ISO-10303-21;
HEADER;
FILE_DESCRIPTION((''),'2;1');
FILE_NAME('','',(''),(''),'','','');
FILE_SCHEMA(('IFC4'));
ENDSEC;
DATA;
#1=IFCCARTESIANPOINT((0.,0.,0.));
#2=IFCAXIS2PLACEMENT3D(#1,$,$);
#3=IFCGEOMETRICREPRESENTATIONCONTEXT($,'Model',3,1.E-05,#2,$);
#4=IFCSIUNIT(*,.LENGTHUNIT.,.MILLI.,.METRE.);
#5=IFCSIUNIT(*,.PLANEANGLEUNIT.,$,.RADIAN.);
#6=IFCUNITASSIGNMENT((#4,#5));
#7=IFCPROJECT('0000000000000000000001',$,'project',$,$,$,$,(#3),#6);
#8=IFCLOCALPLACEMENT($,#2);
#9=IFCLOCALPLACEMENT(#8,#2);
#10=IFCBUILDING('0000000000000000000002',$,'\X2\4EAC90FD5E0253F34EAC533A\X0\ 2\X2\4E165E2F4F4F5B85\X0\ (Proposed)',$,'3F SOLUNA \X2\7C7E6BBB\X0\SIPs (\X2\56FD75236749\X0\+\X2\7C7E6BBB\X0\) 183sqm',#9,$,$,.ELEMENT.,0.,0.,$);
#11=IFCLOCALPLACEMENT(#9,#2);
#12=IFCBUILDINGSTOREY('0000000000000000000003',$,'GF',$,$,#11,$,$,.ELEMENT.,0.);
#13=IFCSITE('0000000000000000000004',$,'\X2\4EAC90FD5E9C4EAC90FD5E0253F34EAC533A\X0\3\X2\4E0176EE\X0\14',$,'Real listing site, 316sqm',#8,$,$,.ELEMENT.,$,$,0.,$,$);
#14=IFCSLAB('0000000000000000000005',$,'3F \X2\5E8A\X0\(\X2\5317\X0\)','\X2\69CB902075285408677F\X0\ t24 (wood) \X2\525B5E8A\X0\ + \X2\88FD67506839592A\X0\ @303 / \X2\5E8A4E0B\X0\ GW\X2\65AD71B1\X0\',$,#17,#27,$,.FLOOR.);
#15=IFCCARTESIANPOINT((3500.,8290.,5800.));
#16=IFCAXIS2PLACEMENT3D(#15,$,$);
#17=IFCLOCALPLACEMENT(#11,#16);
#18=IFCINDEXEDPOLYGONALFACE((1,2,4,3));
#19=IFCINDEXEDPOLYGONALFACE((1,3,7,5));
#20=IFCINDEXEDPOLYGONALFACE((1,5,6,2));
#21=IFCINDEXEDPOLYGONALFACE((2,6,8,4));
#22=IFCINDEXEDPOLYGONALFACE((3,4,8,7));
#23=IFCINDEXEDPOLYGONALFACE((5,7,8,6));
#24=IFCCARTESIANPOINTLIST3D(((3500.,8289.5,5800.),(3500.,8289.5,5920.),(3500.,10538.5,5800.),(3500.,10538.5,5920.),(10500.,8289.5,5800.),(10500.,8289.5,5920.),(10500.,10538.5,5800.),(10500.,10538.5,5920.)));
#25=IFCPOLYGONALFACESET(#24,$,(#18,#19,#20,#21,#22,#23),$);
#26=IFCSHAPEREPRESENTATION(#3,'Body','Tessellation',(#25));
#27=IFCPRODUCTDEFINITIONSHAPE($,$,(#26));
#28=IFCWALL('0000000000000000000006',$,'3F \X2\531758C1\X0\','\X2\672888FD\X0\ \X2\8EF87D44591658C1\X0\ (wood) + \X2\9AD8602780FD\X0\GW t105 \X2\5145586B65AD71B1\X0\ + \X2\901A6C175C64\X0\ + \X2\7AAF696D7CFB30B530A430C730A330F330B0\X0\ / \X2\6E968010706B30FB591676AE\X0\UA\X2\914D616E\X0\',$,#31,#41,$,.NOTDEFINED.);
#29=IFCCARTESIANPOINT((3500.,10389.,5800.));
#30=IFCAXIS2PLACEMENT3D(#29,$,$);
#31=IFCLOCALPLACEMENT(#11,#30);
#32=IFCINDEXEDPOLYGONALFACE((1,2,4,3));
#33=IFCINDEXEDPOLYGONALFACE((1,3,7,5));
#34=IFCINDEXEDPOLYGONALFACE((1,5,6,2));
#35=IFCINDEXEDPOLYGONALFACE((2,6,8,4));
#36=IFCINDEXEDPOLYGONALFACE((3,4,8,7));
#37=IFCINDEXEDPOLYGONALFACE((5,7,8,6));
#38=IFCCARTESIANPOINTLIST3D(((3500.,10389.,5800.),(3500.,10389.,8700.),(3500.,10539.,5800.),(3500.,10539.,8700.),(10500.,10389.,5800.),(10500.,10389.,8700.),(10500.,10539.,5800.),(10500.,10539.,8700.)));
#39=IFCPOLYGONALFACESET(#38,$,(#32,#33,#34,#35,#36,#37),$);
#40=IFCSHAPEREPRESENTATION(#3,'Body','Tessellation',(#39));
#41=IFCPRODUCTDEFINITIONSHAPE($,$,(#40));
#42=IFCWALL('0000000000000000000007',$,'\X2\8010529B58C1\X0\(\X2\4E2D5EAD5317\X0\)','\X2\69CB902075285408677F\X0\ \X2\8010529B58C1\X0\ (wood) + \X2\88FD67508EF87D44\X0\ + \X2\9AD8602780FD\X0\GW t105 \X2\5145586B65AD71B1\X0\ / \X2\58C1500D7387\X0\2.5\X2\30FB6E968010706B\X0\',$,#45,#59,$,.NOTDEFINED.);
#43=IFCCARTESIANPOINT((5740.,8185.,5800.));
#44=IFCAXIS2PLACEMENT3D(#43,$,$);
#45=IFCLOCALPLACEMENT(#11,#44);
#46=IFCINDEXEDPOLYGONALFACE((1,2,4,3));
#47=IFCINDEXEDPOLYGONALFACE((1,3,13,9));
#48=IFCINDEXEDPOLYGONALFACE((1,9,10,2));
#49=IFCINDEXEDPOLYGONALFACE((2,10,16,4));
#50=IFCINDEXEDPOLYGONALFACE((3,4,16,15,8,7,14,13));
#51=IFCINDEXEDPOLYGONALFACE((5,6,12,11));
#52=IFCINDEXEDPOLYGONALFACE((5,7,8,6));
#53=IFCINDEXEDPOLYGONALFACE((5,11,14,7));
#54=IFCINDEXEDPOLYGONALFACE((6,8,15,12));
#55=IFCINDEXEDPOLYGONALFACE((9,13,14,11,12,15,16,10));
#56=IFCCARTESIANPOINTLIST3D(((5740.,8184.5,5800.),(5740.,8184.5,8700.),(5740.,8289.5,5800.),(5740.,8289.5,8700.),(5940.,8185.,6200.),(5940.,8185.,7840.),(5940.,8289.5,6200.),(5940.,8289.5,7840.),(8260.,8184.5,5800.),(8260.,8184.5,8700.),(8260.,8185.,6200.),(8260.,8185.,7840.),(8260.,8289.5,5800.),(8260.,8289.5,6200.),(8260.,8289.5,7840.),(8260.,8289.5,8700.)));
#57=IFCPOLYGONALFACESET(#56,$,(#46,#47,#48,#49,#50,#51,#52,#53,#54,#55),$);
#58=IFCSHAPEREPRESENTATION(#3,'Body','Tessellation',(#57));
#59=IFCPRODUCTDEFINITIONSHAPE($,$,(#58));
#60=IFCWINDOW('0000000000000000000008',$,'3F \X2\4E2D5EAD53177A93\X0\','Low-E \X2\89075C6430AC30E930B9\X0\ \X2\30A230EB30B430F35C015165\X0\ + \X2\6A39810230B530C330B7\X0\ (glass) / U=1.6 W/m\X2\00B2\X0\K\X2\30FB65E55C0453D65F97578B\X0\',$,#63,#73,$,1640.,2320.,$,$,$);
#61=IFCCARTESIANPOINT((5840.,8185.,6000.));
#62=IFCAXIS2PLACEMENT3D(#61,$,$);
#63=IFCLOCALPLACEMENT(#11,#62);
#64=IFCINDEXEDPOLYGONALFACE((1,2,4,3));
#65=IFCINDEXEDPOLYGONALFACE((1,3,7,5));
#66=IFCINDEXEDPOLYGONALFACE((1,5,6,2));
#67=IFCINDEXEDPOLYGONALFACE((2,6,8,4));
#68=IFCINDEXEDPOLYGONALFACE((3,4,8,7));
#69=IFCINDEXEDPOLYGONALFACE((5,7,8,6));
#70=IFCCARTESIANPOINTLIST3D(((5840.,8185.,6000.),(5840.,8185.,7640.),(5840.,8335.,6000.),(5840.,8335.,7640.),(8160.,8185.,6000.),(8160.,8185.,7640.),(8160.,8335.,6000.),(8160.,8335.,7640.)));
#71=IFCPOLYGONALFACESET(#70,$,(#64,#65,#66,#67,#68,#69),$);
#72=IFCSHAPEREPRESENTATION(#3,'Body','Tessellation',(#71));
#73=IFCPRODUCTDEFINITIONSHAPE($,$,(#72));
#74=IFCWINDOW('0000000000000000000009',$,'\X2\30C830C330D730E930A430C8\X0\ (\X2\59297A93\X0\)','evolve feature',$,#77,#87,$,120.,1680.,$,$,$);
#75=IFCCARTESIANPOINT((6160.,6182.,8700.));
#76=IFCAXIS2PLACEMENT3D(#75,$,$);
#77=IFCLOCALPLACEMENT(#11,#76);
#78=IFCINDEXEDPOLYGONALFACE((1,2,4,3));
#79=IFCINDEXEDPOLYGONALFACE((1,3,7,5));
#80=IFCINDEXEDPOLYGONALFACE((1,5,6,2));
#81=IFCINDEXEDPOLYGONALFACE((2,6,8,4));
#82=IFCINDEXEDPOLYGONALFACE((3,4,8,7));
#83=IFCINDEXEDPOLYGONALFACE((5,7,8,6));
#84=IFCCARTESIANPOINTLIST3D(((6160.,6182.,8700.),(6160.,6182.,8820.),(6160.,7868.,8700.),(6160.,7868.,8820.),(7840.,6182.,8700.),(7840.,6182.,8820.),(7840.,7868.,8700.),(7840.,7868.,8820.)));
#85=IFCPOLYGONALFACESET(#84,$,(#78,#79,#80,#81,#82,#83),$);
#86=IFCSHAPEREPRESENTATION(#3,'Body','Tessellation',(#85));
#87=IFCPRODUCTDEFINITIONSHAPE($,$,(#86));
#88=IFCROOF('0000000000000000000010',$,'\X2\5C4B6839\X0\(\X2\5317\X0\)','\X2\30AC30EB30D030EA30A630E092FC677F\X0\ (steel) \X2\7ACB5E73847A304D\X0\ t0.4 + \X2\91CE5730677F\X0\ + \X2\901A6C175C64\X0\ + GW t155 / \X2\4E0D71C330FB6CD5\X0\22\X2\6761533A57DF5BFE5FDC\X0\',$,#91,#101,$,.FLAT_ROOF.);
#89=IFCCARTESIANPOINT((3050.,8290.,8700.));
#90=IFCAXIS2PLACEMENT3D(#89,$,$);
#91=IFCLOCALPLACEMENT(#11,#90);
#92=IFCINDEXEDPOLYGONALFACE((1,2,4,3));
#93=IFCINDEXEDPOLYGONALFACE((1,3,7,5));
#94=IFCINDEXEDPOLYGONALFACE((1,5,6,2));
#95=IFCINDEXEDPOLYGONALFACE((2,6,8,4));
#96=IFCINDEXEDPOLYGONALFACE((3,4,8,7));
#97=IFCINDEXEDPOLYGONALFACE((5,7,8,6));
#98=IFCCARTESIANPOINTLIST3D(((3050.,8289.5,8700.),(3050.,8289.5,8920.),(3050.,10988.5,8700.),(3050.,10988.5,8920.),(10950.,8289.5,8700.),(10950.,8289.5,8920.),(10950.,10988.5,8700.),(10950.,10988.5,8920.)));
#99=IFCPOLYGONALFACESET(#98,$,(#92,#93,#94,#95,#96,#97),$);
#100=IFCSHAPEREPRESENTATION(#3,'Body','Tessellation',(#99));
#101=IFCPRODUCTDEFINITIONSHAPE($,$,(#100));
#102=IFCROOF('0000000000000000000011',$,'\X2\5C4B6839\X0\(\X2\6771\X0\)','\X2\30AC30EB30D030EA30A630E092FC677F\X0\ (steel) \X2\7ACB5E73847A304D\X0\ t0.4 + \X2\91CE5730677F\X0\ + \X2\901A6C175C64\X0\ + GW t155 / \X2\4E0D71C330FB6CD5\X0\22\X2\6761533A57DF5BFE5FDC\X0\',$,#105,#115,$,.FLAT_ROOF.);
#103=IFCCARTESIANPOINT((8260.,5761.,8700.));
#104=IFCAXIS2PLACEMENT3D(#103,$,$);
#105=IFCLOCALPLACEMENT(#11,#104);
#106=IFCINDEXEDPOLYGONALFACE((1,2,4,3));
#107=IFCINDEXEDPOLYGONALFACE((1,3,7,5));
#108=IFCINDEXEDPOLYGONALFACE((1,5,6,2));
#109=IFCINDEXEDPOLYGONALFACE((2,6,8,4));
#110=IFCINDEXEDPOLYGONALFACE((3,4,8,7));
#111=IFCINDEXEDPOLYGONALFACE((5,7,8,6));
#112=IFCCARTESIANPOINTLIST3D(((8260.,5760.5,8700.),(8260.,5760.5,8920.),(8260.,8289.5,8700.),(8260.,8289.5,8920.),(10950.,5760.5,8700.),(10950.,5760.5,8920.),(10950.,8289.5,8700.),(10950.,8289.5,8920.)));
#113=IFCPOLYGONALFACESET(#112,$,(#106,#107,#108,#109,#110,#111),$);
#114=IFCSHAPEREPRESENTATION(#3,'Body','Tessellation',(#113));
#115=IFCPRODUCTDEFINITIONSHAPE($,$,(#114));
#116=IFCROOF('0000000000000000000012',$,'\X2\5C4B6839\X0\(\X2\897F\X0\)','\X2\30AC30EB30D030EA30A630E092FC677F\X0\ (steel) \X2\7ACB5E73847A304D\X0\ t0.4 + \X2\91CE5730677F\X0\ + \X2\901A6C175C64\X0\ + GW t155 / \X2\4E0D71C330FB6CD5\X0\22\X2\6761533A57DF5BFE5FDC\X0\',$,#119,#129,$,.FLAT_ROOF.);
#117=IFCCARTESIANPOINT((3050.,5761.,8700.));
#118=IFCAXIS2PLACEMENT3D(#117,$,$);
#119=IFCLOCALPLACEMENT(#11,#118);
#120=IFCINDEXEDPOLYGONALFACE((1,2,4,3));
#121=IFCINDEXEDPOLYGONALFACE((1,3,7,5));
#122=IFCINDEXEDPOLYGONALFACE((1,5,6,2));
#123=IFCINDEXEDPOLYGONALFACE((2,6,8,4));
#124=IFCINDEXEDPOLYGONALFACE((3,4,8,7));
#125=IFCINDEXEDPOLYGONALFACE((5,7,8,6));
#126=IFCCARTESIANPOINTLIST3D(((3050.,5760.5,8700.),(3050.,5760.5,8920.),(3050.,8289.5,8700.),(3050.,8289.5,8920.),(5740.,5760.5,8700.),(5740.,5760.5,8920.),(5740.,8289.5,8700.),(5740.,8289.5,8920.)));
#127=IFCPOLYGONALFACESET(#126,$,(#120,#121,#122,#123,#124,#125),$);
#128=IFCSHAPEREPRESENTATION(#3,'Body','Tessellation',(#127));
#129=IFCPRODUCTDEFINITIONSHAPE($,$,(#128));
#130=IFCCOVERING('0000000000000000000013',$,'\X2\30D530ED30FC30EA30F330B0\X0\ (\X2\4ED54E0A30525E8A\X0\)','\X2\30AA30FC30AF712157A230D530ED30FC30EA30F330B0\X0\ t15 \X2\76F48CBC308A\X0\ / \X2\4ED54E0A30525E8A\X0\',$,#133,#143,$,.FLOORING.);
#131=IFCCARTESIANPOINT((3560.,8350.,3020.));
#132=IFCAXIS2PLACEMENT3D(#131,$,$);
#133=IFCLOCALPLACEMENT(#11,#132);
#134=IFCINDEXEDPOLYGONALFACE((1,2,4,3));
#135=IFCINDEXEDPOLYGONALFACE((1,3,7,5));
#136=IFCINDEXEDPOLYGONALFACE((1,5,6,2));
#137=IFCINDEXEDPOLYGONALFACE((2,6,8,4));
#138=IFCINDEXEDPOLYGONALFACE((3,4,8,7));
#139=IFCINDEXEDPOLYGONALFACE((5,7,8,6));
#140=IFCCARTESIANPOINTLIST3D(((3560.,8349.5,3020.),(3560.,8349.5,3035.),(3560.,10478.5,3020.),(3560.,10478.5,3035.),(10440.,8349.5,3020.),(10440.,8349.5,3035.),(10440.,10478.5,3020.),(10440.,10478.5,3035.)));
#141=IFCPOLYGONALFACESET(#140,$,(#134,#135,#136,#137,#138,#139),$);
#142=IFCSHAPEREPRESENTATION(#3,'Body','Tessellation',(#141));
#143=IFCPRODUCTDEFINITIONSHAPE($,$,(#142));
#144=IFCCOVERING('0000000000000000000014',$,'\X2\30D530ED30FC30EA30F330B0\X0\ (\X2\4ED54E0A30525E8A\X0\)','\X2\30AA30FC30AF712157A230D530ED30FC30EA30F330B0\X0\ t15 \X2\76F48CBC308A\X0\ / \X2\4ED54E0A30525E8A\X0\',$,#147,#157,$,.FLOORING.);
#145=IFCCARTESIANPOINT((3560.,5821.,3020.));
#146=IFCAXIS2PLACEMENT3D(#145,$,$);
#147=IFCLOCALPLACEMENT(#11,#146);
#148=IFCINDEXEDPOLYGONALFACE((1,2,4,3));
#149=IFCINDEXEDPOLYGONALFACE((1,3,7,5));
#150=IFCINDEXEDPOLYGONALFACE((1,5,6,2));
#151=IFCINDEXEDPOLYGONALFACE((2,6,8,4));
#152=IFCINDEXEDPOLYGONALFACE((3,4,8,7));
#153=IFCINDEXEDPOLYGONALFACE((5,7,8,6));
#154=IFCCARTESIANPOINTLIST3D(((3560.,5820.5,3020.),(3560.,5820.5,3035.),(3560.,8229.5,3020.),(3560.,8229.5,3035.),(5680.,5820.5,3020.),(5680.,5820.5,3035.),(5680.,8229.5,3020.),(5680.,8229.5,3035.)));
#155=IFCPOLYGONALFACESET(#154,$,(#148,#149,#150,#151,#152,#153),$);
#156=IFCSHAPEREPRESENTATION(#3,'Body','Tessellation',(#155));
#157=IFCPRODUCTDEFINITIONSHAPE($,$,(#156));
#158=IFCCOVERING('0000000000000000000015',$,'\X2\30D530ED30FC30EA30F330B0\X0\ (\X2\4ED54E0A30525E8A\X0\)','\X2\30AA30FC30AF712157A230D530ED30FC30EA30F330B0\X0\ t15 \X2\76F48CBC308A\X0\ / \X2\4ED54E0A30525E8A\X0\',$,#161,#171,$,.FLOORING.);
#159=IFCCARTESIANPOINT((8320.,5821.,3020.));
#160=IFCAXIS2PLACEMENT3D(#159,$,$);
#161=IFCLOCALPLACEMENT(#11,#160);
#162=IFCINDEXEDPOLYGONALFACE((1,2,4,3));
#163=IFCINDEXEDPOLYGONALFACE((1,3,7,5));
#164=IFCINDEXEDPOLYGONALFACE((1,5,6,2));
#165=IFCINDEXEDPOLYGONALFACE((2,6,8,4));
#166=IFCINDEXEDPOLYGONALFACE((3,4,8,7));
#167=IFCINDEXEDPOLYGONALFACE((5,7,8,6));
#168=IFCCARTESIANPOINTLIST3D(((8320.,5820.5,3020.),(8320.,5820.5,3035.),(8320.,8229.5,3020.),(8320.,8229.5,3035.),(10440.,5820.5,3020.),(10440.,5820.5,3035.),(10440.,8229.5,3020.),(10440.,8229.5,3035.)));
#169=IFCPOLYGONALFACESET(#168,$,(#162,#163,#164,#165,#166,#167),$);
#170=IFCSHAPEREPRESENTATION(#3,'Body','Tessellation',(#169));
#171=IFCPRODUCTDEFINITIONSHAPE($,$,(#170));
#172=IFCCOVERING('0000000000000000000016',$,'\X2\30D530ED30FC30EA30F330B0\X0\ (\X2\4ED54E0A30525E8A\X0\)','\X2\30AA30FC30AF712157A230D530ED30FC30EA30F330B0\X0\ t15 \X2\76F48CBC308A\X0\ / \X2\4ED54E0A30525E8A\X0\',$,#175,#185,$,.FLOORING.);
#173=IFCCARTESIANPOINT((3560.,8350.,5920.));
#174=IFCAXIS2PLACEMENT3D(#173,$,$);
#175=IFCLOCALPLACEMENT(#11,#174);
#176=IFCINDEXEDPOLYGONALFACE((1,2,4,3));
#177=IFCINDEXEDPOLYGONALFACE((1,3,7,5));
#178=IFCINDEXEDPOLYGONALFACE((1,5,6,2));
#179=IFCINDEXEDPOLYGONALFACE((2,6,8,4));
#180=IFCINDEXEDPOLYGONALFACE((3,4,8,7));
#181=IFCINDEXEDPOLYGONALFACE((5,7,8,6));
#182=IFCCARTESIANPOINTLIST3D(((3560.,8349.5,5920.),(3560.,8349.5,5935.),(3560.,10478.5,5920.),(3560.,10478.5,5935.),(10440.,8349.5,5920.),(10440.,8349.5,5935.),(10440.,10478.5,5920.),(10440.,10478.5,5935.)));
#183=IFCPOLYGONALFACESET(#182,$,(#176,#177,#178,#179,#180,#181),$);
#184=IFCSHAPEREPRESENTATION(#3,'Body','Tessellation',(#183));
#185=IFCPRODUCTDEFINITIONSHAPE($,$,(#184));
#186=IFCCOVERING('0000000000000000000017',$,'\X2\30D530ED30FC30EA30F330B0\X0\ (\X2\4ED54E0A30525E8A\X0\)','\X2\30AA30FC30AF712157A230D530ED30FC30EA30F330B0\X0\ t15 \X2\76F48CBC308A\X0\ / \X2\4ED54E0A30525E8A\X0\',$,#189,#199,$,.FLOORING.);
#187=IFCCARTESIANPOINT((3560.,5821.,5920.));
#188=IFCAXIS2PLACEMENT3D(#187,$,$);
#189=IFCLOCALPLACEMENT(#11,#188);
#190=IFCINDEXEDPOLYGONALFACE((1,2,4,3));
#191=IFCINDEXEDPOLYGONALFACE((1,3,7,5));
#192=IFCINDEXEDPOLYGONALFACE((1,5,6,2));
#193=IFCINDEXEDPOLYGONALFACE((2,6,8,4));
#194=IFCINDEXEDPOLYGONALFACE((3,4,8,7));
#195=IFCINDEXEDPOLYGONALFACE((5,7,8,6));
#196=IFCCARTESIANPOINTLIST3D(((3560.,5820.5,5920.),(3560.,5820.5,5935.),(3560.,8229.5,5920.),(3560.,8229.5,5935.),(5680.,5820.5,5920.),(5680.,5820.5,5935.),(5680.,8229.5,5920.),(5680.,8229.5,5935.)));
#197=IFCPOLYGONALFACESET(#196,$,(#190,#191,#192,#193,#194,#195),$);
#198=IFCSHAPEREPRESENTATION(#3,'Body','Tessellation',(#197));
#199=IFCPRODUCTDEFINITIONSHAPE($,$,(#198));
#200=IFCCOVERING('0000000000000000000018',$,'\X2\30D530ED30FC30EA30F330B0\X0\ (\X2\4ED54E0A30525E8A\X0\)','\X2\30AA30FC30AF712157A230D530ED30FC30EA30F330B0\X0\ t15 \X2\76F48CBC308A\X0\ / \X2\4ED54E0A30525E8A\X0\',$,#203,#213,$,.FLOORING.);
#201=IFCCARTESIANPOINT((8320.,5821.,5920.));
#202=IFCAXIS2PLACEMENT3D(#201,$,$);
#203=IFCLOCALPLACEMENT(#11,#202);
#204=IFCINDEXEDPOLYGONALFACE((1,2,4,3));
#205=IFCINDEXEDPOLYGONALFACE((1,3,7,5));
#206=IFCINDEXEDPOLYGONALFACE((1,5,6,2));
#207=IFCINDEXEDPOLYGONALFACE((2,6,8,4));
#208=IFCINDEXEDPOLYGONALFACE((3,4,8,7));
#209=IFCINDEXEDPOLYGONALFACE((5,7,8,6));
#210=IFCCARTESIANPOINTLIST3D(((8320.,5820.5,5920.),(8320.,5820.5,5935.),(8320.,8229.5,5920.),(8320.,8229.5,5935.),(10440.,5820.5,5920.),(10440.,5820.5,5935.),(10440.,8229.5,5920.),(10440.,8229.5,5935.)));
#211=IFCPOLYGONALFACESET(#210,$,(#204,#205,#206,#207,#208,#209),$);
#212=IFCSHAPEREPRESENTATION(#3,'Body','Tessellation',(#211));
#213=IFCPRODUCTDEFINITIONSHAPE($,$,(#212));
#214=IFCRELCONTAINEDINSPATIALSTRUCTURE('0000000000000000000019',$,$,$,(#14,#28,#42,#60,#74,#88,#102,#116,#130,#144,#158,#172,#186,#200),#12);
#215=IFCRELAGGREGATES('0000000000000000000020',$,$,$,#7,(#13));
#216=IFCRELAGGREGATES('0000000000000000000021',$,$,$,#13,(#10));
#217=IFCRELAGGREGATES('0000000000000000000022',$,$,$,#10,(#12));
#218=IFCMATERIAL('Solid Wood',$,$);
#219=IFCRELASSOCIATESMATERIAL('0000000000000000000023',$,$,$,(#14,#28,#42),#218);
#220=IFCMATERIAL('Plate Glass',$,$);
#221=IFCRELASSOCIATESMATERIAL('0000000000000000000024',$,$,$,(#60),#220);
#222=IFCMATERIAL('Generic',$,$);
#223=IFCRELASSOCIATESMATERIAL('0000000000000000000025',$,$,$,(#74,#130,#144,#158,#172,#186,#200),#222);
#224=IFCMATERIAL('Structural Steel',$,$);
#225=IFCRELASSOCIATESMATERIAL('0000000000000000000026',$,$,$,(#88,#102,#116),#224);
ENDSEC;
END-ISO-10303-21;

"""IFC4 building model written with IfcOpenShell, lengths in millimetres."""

from ifc_helpers import new_model, si_unit, frame, frame_2d, origin, place, context, project, spatial, rectangle, extrude, material, element, fill, save


model = new_model("IFC4")

# Units and contexts
model_context = context("Model", 3, precision=1e-05, world=origin())
ifc_project = project(units=[si_unit("LENGTHUNIT", "METRE", prefix="MILLI"), si_unit("PLANEANGLEUNIT", "RADIAN")], contexts=[model_context])

# Site, building, storey
site_placement = place(None, origin())
site = spatial("IfcSite", under=ifc_project, at=site_placement, Name="京都府京都市右京区3丁目14", ObjectType="Real listing site, 316sqm", CompositionType="ELEMENT", RefElevation=0.0)
building_placement = place(site_placement, origin())
building = spatial("IfcBuilding", under=site, at=building_placement, Name="京都市右京区 2世帯住宅 (Proposed)", ObjectType="3F SOLUNA 籾殻SIPs (国産杉+籾殻) 183sqm", CompositionType="ELEMENT", ElevationOfRefHeight=0.0, ElevationOfTerrain=0.0)
storey_placement = place(building_placement, origin())
storey = spatial("IfcBuildingStorey", under=building, at=storey_placement, Name="GF", CompositionType="ELEMENT", Elevation=0.0)

# Slab
ifc_material_1 = material(Name="Solid Wood")
slab_placement = place(storey_placement, frame((3500.0, 8290.0, 5800.0)))
element("IfcSlab", 1, at=slab_placement, inside=storey, material=ifc_material_1, Name="3F 床(北)", Description="構造用合板 t24 (wood) 剛床 + 製材根太 @303 / 床下 GW断熱", PredefinedType="FLOOR", context=model_context, shape_type="SweptSolid", body=[
    extrude(rectangle(XDim=7000.0, YDim=2249.0, at=frame_2d((3500.0, 1124.0))), frame((3500.0, 8290.0, 5800.0)), (0.0, 0.0, 1.0), 120.0),
])

# Wall
wall_1_placement = place(storey_placement, frame((3500.0, 10389.0, 5800.0)))
element("IfcWall", 2, at=wall_1_placement, inside=storey, material=ifc_material_1, Name="3F 北壁", Description="木製 軸組外壁 (wood) + 高性能GW t105 充填断熱 + 通気層 + 窯業系サイディング / 準耐火・外皮UA配慮", PredefinedType="NOTDEFINED", context=model_context, shape_type="SweptSolid", body=[
    extrude(rectangle(XDim=7000.0, YDim=150.0, at=frame_2d((3500.0, 75.0))), frame((3500.0, 10389.0, 5800.0)), (0.0, 0.0, 1.0), 2900.0),
])

# Wall, opening, window
wall_2_placement = place(storey_placement, frame((5740.0, 8185.0, 5800.0)))
wall_2 = element("IfcWall", 3, at=wall_2_placement, inside=storey, material=ifc_material_1, Name="耐力壁(中庭北)", Description="構造用合板 耐力壁 (wood) + 製材軸組 + 高性能GW t105 充填断熱 / 壁倍率2.5・準耐火", PredefinedType="NOTDEFINED", context=model_context, shape_type="SweptSolid", body=[
    extrude(rectangle(XDim=2520.0, YDim=105.0, at=frame_2d((1260.0, 52.0))), frame((5740.0, 8185.0, 5800.0)), (0.0, 0.0, 1.0), 2900.0),
])
opening_placement = place(storey_placement, frame((5840.0, 8185.0, 6000.0)))
opening = element("IfcOpeningElement", 4, at=opening_placement, cuts=wall_2, PredefinedType="NOTDEFINED", context=model_context, shape_type="SweptSolid", body=[
    extrude(rectangle(XDim=2320.0, YDim=150.0, at=frame_2d((1160.0, 75.0))), frame((5840.0, 8185.0, 6000.0)), (0.0, 0.0, 1.0), 1640.0),
])
ifc_material_2 = material(Name="Plate Glass")
window_1_placement = place(storey_placement, frame((5840.0, 8185.0, 6000.0)))
window_1 = element("IfcWindow", 5, at=window_1_placement, inside=storey, material=ifc_material_2, Name="3F 中庭北窓", Description="Low-E 複層ガラス アルゴン封入 + 樹脂サッシ (glass) / U=1.6 W/m²K・日射取得型", OverallHeight=1640.0, OverallWidth=2320.0, context=model_context, shape_type="SweptSolid", body=[
    extrude(rectangle(XDim=2320.0, YDim=150.0, at=frame_2d((1160.0, 75.0))), frame((5840.0, 8185.0, 6000.0)), (0.0, 0.0, 1.0), 1640.0),
])
fill(opening, window_1)

# Window
ifc_material_3 = material(Name="Generic")
window_2_placement = place(storey_placement, frame((6160.0, 6182.0, 8700.0)))
element("IfcWindow", 6, at=window_2_placement, inside=storey, material=ifc_material_3, Name="トップライト (天窓)", Description="evolve feature", OverallHeight=120.0, OverallWidth=1680.0, context=model_context, shape_type="SweptSolid", body=[
    extrude(rectangle(XDim=1680.0, YDim=1686.0, at=frame_2d((840.0, 843.0))), frame((6160.0, 6182.0, 8700.0)), (0.0, 0.0, 1.0), 120.0),
])

# Roofs
ifc_material_4 = material(Name="Structural Steel")
roof_1_placement = place(storey_placement, frame((3050.0, 8290.0, 8700.0)))
element("IfcRoof", 7, at=roof_1_placement, inside=storey, material=ifc_material_4, Name="屋根(北)", Description="ガルバリウム鋼板 (steel) 立平葺き t0.4 + 野地板 + 通気層 + GW t155 / 不燃・法22条区域対応", PredefinedType="FLAT_ROOF", context=model_context, shape_type="SweptSolid", body=[
    extrude(rectangle(XDim=7900.0, YDim=2699.0, at=frame_2d((3950.0, 1349.0))), frame((3050.0, 8290.0, 8700.0)), (0.0, 0.0, 1.0), 220.0),
])
roof_2_placement = place(storey_placement, frame((8260.0, 5761.0, 8700.0)))
element("IfcRoof", 8, at=roof_2_placement, inside=storey, material=ifc_material_4, Name="屋根(東)", Description="ガルバリウム鋼板 (steel) 立平葺き t0.4 + 野地板 + 通気層 + GW t155 / 不燃・法22条区域対応", PredefinedType="FLAT_ROOF", context=model_context, shape_type="SweptSolid", body=[
    extrude(rectangle(XDim=2690.0, YDim=2529.0, at=frame_2d((1345.0, 1264.0))), frame((8260.0, 5761.0, 8700.0)), (0.0, 0.0, 1.0), 220.0),
])
roof_3_placement = place(storey_placement, frame((3050.0, 5761.0, 8700.0)))
element("IfcRoof", 9, at=roof_3_placement, inside=storey, material=ifc_material_4, Name="屋根(西)", Description="ガルバリウム鋼板 (steel) 立平葺き t0.4 + 野地板 + 通気層 + GW t155 / 不燃・法22条区域対応", PredefinedType="FLAT_ROOF", context=model_context, shape_type="SweptSolid", body=[
    extrude(rectangle(XDim=2690.0, YDim=2529.0, at=frame_2d((1345.0, 1264.0))), frame((3050.0, 5761.0, 8700.0)), (0.0, 0.0, 1.0), 220.0),
])

# Coverings
covering_1_placement = place(storey_placement, frame((3560.0, 8350.0, 3020.0)))
element("IfcCovering", 10, at=covering_1_placement, inside=storey, material=ifc_material_3, Name="フローリング (仕上げ床)", Description="オーク無垢フローリング t15 直貼り / 仕上げ床", PredefinedType="FLOORING", context=model_context, shape_type="SweptSolid", body=[
    extrude(rectangle(XDim=6880.0, YDim=2129.0, at=frame_2d((3440.0, 1064.0))), frame((3560.0, 8350.0, 3020.0)), (0.0, 0.0, 1.0), 15.0),
])
covering_2_placement = place(storey_placement, frame((3560.0, 5821.0, 3020.0)))
element("IfcCovering", 11, at=covering_2_placement, inside=storey, material=ifc_material_3, Name="フローリング (仕上げ床)", Description="オーク無垢フローリング t15 直貼り / 仕上げ床", PredefinedType="FLOORING", context=model_context, shape_type="SweptSolid", body=[
    extrude(rectangle(XDim=2120.0, YDim=2409.0, at=frame_2d((1060.0, 1204.0))), frame((3560.0, 5821.0, 3020.0)), (0.0, 0.0, 1.0), 15.0),
])
covering_3_placement = place(storey_placement, frame((8320.0, 5821.0, 3020.0)))
element("IfcCovering", 12, at=covering_3_placement, inside=storey, material=ifc_material_3, Name="フローリング (仕上げ床)", Description="オーク無垢フローリング t15 直貼り / 仕上げ床", PredefinedType="FLOORING", context=model_context, shape_type="SweptSolid", body=[
    extrude(rectangle(XDim=2120.0, YDim=2409.0, at=frame_2d((1060.0, 1204.0))), frame((8320.0, 5821.0, 3020.0)), (0.0, 0.0, 1.0), 15.0),
])
covering_4_placement = place(storey_placement, frame((3560.0, 8350.0, 5920.0)))
element("IfcCovering", 13, at=covering_4_placement, inside=storey, material=ifc_material_3, Name="フローリング (仕上げ床)", Description="オーク無垢フローリング t15 直貼り / 仕上げ床", PredefinedType="FLOORING", context=model_context, shape_type="SweptSolid", body=[
    extrude(rectangle(XDim=6880.0, YDim=2129.0, at=frame_2d((3440.0, 1064.0))), frame((3560.0, 8350.0, 5920.0)), (0.0, 0.0, 1.0), 15.0),
])
covering_5_placement = place(storey_placement, frame((3560.0, 5821.0, 5920.0)))
element("IfcCovering", 14, at=covering_5_placement, inside=storey, material=ifc_material_3, Name="フローリング (仕上げ床)", Description="オーク無垢フローリング t15 直貼り / 仕上げ床", PredefinedType="FLOORING", context=model_context, shape_type="SweptSolid", body=[
    extrude(rectangle(XDim=2120.0, YDim=2409.0, at=frame_2d((1060.0, 1204.0))), frame((3560.0, 5821.0, 5920.0)), (0.0, 0.0, 1.0), 15.0),
])
covering_6_placement = place(storey_placement, frame((8320.0, 5821.0, 5920.0)))
element("IfcCovering", 15, at=covering_6_placement, inside=storey, material=ifc_material_3, Name="フローリング (仕上げ床)", Description="オーク無垢フローリング t15 直貼り / 仕上げ床", PredefinedType="FLOORING", context=model_context, shape_type="SweptSolid", body=[
    extrude(rectangle(XDim=2120.0, YDim=2409.0, at=frame_2d((1060.0, 1204.0))), frame((8320.0, 5821.0, 5920.0)), (0.0, 0.0, 1.0), 15.0),
])

save(model, "model.ifc")
